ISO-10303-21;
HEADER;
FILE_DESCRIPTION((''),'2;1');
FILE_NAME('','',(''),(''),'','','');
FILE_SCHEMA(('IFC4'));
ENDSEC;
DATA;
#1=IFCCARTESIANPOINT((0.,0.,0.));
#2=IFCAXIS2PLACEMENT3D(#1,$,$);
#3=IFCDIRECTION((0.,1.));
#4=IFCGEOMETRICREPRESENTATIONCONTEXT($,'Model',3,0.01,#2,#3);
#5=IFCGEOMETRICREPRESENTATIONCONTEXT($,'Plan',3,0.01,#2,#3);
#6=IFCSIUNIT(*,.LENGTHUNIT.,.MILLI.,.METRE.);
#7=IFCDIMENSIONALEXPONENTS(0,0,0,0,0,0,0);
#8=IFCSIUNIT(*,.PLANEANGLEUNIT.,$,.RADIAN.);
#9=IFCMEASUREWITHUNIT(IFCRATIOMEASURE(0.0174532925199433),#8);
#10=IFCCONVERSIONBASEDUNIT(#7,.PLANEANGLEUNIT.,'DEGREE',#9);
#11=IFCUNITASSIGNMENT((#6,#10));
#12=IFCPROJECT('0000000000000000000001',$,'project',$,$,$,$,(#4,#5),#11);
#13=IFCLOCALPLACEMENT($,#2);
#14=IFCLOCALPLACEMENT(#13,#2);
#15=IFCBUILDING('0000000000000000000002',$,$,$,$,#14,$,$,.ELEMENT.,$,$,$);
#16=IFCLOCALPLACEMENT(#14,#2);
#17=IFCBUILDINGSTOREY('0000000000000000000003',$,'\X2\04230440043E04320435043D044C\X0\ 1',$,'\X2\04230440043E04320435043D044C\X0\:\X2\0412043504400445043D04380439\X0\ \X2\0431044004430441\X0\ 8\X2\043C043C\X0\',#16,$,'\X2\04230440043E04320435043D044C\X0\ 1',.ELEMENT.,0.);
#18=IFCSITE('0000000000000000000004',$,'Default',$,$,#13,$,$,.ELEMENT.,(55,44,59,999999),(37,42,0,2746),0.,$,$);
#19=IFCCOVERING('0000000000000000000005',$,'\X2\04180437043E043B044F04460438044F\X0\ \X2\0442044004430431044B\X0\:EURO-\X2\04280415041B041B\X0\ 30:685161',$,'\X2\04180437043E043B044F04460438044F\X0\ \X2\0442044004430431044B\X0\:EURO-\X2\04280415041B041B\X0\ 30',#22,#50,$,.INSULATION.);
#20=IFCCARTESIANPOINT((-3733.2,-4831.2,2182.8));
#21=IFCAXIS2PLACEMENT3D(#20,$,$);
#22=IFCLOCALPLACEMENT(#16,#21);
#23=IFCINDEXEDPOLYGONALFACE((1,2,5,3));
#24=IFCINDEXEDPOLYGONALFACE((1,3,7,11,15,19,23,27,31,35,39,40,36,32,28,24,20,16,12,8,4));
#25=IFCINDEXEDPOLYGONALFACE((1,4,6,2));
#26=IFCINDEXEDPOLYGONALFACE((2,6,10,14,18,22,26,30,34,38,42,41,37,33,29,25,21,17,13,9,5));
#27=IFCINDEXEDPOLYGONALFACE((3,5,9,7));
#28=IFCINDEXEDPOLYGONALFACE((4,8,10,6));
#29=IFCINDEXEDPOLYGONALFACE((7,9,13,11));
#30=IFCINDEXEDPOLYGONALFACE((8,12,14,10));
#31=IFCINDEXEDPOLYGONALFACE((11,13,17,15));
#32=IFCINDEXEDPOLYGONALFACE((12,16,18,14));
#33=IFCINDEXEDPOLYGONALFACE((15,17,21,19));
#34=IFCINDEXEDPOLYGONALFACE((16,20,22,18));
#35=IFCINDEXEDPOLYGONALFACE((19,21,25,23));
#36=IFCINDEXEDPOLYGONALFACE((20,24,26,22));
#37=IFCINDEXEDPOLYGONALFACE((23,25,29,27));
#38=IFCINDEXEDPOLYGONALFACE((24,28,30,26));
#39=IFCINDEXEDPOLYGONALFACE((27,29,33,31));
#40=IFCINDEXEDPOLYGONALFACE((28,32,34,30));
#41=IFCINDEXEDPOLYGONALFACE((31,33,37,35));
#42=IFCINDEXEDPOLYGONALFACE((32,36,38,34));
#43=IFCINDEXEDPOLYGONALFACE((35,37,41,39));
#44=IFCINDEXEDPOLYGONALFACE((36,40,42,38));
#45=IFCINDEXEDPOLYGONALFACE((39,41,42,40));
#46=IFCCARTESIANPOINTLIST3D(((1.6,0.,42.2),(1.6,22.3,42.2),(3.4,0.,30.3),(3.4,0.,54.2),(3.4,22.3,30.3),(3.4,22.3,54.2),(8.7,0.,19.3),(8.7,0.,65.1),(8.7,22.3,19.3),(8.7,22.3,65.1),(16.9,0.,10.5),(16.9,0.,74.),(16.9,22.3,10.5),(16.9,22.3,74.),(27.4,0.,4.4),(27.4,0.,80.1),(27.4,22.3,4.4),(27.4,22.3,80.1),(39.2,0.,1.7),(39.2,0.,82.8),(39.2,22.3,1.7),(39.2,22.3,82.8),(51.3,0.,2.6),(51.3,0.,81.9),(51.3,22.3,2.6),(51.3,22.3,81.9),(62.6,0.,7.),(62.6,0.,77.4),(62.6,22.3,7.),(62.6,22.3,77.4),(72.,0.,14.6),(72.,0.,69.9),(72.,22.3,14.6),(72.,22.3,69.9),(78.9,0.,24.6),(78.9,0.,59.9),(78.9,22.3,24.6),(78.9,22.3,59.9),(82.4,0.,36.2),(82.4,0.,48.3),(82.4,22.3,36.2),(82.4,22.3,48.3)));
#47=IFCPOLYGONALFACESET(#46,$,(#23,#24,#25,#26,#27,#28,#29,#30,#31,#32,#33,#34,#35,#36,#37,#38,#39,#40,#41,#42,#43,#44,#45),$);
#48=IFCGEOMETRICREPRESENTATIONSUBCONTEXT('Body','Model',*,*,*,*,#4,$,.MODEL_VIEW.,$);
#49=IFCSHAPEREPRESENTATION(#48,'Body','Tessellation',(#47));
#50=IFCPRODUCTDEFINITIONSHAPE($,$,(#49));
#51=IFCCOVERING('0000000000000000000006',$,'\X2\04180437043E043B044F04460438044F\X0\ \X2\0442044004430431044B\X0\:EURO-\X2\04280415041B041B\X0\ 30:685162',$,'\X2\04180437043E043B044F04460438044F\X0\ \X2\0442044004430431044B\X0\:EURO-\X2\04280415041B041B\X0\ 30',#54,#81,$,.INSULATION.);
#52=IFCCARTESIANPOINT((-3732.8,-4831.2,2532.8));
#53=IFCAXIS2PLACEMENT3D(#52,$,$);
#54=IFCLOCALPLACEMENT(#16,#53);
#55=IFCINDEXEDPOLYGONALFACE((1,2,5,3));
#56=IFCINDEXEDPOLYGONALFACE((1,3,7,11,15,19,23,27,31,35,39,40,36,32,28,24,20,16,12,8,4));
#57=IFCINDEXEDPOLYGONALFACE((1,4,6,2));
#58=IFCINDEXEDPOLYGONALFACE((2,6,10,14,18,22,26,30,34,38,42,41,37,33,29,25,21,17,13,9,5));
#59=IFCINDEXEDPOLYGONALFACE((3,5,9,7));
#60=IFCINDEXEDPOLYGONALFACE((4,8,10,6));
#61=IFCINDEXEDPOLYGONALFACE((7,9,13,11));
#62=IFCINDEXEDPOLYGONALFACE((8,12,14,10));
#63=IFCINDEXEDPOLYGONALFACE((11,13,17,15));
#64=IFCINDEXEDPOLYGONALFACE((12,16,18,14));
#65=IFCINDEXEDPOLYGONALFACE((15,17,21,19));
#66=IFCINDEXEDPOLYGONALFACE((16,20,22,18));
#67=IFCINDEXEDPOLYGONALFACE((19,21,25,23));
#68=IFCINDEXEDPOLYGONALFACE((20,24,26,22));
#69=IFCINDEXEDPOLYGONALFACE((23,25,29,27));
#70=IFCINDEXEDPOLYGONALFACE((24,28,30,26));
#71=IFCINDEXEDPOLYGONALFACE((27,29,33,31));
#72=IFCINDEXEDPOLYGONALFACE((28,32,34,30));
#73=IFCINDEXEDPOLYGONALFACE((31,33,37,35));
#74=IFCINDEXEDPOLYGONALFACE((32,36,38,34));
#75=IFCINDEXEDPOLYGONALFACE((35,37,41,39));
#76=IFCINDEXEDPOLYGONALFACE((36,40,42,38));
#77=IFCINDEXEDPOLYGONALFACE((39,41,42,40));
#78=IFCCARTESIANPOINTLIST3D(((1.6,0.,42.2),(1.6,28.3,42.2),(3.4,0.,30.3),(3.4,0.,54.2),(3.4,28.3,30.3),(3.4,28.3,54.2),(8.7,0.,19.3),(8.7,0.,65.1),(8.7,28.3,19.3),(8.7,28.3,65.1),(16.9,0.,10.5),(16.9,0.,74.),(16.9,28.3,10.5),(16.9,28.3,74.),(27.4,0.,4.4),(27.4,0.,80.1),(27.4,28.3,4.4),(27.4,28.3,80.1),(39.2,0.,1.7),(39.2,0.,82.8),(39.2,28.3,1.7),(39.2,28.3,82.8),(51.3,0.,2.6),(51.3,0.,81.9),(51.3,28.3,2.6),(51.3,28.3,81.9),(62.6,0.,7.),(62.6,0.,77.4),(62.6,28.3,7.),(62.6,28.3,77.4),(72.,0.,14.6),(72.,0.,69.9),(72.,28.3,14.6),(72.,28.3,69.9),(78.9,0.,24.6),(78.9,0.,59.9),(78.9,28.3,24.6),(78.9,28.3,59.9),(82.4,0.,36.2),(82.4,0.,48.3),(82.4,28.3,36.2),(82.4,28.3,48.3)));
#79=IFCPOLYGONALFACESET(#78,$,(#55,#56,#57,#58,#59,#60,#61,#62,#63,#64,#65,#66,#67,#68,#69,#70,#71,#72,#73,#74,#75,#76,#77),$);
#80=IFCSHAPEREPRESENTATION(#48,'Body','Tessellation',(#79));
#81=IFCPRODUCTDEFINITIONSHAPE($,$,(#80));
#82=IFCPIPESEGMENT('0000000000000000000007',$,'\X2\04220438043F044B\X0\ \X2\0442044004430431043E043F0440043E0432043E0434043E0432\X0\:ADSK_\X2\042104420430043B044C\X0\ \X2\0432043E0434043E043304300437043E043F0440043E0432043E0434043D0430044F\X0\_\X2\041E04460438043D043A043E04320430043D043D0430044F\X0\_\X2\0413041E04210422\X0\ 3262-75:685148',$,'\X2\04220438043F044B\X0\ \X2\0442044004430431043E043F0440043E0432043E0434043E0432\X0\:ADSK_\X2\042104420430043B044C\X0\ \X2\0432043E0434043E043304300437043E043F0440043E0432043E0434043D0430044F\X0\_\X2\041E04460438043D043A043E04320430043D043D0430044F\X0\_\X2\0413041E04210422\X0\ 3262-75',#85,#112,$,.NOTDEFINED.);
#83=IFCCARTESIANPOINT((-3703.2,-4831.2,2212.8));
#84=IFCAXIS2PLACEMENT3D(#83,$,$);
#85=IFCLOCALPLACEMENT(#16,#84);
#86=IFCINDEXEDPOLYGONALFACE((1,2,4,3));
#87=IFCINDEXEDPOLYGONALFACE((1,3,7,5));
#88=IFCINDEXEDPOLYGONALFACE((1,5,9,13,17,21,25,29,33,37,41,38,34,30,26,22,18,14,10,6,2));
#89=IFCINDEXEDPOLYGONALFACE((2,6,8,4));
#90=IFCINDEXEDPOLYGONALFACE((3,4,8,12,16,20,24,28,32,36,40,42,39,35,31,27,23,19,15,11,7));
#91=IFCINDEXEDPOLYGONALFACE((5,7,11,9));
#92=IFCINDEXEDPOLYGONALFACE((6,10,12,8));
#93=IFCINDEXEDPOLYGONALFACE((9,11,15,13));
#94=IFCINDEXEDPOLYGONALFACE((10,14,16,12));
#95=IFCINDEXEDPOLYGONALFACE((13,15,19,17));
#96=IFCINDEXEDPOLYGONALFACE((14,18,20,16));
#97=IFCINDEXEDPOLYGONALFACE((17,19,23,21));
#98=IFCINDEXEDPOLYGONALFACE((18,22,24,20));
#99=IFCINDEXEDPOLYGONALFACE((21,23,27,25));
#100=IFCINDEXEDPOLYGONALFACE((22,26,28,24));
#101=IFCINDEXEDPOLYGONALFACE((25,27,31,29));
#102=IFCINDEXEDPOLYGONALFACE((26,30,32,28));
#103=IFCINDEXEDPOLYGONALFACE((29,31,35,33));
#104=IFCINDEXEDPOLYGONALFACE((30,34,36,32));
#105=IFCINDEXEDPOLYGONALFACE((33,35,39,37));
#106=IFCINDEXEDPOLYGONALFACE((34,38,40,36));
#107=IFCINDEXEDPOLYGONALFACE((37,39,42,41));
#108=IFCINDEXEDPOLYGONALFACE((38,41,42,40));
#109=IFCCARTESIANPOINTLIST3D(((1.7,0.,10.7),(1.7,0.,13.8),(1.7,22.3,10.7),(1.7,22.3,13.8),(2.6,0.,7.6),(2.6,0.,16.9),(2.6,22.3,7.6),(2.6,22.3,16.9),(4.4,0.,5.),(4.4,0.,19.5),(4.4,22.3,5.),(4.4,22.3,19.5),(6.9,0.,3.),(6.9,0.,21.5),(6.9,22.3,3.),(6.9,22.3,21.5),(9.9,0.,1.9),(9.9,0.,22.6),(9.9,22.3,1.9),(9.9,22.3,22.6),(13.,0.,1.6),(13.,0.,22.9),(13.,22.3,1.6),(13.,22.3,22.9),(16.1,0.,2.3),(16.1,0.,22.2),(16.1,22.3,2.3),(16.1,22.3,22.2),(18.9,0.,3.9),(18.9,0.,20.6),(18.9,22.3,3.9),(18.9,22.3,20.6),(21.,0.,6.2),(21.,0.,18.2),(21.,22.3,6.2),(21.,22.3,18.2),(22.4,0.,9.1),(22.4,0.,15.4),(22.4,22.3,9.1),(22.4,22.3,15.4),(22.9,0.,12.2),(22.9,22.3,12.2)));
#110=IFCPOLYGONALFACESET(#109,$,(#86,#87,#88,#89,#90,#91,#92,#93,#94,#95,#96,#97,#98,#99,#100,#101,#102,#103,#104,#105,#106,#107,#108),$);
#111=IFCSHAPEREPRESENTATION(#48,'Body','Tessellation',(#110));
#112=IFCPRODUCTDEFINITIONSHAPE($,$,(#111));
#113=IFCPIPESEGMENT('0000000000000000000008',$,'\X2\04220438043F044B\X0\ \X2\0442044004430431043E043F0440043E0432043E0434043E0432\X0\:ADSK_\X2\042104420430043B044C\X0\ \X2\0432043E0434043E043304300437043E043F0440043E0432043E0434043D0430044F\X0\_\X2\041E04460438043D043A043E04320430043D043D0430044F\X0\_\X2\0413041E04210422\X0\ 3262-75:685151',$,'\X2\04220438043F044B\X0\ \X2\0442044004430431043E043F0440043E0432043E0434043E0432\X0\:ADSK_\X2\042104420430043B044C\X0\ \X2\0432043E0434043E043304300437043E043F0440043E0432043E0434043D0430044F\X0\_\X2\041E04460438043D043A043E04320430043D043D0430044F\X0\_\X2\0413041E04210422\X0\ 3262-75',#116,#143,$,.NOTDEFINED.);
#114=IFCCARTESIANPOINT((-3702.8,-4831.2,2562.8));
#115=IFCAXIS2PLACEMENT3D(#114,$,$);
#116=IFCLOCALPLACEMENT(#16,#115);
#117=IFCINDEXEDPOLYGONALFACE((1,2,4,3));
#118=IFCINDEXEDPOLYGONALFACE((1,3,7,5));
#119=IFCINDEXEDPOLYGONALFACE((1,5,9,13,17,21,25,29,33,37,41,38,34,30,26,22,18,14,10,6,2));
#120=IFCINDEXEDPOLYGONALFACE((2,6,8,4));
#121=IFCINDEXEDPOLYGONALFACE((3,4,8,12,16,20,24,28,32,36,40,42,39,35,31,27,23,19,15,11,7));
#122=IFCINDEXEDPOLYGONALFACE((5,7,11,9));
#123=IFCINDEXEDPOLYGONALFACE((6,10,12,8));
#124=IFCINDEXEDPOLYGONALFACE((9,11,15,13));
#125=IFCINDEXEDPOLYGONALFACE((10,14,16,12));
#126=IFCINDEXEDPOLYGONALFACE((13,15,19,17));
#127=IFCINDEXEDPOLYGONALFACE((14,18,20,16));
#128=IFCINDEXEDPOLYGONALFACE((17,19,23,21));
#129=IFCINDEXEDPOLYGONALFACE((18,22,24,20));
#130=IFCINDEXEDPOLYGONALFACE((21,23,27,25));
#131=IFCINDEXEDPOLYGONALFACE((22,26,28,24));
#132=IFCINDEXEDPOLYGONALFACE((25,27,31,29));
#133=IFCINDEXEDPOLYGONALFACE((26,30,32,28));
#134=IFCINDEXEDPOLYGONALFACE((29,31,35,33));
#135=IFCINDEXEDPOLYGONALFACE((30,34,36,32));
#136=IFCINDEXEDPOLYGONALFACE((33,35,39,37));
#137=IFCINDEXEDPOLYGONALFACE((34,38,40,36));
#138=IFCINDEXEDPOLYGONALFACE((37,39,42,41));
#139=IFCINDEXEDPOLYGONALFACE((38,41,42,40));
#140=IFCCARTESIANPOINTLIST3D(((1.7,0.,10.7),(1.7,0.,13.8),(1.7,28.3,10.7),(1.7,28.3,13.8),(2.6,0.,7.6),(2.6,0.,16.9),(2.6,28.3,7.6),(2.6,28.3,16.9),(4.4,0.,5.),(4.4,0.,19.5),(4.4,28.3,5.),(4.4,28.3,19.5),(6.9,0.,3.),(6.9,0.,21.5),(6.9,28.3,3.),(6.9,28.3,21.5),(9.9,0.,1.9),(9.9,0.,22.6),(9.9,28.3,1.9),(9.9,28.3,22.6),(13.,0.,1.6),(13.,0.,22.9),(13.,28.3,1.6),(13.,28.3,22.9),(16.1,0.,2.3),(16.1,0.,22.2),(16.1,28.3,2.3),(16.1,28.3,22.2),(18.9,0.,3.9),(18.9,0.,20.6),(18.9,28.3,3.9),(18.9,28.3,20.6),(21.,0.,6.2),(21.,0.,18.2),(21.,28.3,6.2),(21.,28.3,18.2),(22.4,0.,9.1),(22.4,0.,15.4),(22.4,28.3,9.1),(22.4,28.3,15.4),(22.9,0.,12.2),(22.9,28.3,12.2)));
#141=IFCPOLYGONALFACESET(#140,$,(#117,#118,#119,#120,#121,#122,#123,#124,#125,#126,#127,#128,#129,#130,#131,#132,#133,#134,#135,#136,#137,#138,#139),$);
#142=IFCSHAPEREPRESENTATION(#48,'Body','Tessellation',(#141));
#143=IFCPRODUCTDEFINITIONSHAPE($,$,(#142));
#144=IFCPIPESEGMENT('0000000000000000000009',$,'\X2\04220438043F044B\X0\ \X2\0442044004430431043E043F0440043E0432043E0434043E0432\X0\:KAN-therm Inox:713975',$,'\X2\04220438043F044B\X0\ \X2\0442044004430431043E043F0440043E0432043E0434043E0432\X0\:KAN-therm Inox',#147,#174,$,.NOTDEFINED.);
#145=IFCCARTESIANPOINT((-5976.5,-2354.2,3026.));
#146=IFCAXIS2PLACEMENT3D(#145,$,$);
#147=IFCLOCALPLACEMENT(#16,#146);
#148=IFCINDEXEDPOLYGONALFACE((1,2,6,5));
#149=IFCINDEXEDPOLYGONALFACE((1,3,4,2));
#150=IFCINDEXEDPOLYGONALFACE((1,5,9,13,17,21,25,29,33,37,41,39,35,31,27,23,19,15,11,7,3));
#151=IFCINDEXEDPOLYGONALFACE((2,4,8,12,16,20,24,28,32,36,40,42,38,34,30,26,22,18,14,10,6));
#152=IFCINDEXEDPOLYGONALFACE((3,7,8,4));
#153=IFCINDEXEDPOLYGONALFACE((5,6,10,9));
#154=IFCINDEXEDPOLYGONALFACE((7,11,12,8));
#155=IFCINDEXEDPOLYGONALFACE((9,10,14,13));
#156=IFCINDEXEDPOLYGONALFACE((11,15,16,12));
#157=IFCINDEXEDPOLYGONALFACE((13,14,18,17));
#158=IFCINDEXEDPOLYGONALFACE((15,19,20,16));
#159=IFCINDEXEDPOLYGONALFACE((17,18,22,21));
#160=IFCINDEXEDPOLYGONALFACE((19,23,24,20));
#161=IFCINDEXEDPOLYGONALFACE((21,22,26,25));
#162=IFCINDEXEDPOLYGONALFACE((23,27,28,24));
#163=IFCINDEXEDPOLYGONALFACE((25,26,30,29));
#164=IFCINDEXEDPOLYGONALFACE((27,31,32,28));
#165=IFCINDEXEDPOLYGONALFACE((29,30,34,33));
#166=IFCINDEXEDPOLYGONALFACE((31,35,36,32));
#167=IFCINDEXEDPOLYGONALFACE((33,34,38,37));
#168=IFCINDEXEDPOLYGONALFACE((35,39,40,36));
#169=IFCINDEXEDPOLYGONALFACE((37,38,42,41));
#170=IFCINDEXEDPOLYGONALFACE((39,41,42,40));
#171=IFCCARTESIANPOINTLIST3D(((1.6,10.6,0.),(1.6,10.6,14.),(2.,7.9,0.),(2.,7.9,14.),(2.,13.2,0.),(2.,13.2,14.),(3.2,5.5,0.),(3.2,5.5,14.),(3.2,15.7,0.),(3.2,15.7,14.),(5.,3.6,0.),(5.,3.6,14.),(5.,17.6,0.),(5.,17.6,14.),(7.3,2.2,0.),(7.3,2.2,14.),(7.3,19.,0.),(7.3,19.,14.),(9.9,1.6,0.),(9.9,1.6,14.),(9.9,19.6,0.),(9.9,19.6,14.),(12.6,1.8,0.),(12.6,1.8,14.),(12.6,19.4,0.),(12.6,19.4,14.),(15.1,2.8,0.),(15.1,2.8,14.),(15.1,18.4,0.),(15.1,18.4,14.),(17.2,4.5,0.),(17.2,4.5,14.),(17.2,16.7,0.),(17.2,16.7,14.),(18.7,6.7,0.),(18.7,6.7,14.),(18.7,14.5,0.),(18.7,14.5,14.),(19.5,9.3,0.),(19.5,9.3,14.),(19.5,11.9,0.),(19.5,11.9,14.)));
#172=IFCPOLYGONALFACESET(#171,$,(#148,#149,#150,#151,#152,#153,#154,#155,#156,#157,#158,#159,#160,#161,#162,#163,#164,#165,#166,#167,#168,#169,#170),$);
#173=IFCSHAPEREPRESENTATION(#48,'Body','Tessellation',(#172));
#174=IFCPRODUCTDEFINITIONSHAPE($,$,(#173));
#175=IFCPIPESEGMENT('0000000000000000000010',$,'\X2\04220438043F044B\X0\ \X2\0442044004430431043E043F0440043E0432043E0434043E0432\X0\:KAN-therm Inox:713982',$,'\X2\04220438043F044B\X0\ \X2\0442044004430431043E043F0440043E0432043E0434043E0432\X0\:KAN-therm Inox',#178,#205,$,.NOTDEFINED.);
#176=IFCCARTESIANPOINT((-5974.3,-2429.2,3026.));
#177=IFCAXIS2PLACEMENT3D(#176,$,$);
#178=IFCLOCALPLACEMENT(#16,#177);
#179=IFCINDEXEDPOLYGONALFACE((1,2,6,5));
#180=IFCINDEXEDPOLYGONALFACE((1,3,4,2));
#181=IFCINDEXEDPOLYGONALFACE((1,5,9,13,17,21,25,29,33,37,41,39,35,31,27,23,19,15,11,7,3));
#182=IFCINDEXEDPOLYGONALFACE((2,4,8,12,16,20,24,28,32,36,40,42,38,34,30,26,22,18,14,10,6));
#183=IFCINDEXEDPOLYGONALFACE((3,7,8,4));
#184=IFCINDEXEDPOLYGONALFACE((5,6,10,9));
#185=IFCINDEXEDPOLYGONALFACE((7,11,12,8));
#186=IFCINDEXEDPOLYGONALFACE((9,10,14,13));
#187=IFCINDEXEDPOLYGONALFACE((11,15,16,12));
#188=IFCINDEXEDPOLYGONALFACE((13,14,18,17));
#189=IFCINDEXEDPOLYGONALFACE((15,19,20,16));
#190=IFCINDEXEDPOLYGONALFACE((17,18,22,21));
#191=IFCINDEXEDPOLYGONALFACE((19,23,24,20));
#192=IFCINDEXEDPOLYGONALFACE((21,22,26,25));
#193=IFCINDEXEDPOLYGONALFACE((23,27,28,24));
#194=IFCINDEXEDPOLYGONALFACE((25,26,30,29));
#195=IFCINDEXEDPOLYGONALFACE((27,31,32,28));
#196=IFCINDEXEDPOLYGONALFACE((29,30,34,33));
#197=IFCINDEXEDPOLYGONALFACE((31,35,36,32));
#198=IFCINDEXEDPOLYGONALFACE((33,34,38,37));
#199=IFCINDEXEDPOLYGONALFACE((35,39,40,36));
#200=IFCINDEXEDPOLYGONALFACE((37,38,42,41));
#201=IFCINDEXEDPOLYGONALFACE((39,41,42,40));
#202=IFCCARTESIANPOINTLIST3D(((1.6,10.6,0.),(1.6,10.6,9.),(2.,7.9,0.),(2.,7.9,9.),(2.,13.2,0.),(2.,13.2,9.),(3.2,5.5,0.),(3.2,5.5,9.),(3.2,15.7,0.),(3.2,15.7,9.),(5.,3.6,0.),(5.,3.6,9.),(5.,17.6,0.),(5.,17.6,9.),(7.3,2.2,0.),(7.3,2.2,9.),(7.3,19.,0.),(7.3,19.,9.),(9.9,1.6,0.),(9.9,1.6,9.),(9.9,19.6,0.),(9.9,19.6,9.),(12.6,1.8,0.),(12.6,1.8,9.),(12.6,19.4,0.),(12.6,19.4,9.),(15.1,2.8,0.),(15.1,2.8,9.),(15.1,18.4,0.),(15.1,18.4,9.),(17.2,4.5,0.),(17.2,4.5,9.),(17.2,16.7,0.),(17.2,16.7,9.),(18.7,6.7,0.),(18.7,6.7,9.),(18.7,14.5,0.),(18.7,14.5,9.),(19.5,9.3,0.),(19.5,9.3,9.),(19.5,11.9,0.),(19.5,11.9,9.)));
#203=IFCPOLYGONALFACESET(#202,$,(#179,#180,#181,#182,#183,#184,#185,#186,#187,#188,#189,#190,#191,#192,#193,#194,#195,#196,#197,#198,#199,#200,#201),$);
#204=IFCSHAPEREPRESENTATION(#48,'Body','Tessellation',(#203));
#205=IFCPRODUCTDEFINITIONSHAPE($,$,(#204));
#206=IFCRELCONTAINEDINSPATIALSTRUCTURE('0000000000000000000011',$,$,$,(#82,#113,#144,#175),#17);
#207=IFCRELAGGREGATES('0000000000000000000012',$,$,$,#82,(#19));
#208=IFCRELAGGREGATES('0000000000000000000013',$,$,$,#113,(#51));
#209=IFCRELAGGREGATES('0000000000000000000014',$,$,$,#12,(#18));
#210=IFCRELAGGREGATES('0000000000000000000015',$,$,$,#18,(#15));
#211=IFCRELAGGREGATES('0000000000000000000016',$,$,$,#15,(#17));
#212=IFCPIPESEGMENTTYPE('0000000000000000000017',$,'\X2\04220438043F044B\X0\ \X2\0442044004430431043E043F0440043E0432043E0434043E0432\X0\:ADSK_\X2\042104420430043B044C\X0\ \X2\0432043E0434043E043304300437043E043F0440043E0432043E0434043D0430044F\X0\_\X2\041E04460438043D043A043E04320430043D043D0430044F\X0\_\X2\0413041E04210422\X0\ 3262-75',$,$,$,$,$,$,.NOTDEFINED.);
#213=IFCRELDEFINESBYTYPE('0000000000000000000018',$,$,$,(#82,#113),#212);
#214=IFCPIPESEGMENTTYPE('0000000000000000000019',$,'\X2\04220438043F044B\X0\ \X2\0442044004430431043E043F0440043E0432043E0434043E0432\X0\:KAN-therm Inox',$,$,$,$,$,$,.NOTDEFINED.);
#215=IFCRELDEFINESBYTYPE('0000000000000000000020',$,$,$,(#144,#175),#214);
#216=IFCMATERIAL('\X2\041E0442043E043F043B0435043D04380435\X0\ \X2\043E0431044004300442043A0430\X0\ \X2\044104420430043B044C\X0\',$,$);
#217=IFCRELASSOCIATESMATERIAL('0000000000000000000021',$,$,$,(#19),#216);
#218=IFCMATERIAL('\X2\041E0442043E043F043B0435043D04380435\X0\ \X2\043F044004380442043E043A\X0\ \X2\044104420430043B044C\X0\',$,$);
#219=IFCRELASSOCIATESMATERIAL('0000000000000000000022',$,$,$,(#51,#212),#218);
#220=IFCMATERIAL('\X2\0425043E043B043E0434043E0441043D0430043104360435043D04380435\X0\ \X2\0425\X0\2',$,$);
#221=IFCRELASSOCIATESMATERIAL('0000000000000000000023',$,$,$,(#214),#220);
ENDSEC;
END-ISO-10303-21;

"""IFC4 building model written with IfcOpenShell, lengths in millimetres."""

from ifc_helpers import new_model, entity, si_unit, converted_unit, direction, frame, origin, origin_2d_with_axis, place, context, subcontext, project, spatial, circle, extrude, material, type_object, element, aggregate, save


model = new_model("IFC4")

# Units and contexts
model_context = context("Model", 3, precision=0.01, world=origin(), true_north=direction((0.0, 1.0)))
plan_context = context("Plan", 3, precision=0.01, world=origin(), true_north=direction((0.0, 1.0)))
body_context = subcontext(model_context, "Body", "Model", "MODEL_VIEW")
ifc_project = project(units=[si_unit("LENGTHUNIT", "METRE", prefix="MILLI"), converted_unit("PLANEANGLEUNIT", "DEGREE", entity("IfcRatioMeasure", 0.0174532925199433), si_unit("PLANEANGLEUNIT", "RADIAN"), dimensions=[0, 0, 0, 0, 0, 0, 0])], contexts=[model_context, plan_context])

# Site, building, storey
site_placement = place(None, origin())
site = spatial("IfcSite", under=ifc_project, at=site_placement, Name="Default", CompositionType="ELEMENT", RefLatitude=(55, 44, 59, 999999), RefLongitude=(37, 42, 0, 2746), RefElevation=0.0)
building_placement = place(site_placement, origin())
building = spatial("IfcBuilding", under=site, at=building_placement, CompositionType="ELEMENT")
storey_placement = place(building_placement, origin())
storey = spatial("IfcBuildingStorey", under=building, at=storey_placement, Name="Уровень 1", ObjectType="Уровень:Верхний брус 8мм", LongName="Уровень 1", CompositionType="ELEMENT", Elevation=0.0)

# Coverings
ifc_material_1 = material(Name="Отопление обратка сталь")
covering_1_placement = place(storey_placement, frame((-3733.2, -4831.2, 2182.8)))
covering_1 = element("IfcCovering", 1, at=covering_1_placement, material=ifc_material_1, Name="Изоляция трубы:EURO-ШЕЛЛ 30:685161", ObjectType="Изоляция трубы:EURO-ШЕЛЛ 30", PredefinedType="INSULATION", context=body_context, shape_type="SweptSolid", body=[
    extrude(circle(Radius=40.6, at=origin_2d_with_axis()), frame((42.2, 0.0, 42.2), z_axis=(0.0, 1.0, 0.0), x_axis=(-1.0, 0.0, 0.0)), (0.0, 0.0, 1.0), 22.3),
])
ifc_material_2 = material(Name="Отопление приток сталь")
covering_2_placement = place(storey_placement, frame((-3732.8, -4831.2, 2532.8)))
covering_2 = element("IfcCovering", 2, at=covering_2_placement, material=ifc_material_2, Name="Изоляция трубы:EURO-ШЕЛЛ 30:685162", ObjectType="Изоляция трубы:EURO-ШЕЛЛ 30", PredefinedType="INSULATION", context=body_context, shape_type="SweptSolid", body=[
    extrude(circle(Radius=40.6, at=origin_2d_with_axis()), frame((42.2, 0.0, 42.2), z_axis=(0.0, 1.0, 0.0), x_axis=(-1.0, 0.0, 0.0)), (0.0, 0.0, 1.0), 28.3),
])
ifc_material_3 = material(Name="Холодоснабжение Х2")

# Pipe segments
pipe_segment_type_1 = type_object("IfcPipeSegmentType", Name="Типы трубопроводов:ADSK_Сталь водогазопроводная_Оцинкованная_ГОСТ 3262-75", PredefinedType="NOTDEFINED", material=ifc_material_2)
pipe_segment_1_placement = place(storey_placement, frame((-3703.2, -4831.2, 2212.8)))
pipe_segment_1 = element("IfcPipeSegment", 3, at=pipe_segment_1_placement, inside=storey, type_object=pipe_segment_type_1, Name="Типы трубопроводов:ADSK_Сталь водогазопроводная_Оцинкованная_ГОСТ 3262-75:685148", ObjectType="Типы трубопроводов:ADSK_Сталь водогазопроводная_Оцинкованная_ГОСТ 3262-75", PredefinedType="NOTDEFINED", context=body_context, shape_type="SweptSolid", body=[
    extrude(circle(Radius=10.7, at=origin_2d_with_axis()), frame((12.2, 0.0, 12.2), z_axis=(0.0, 1.0, 0.0), x_axis=(1.0, 0.0, 0.0)), (0.0, 0.0, 1.0), 22.3),
])
aggregate(pipe_segment_1, [covering_1])
pipe_segment_2_placement = place(storey_placement, frame((-3702.8, -4831.2, 2562.8)))
pipe_segment_2 = element("IfcPipeSegment", 4, at=pipe_segment_2_placement, inside=storey, type_object=pipe_segment_type_1, Name="Типы трубопроводов:ADSK_Сталь водогазопроводная_Оцинкованная_ГОСТ 3262-75:685151", ObjectType="Типы трубопроводов:ADSK_Сталь водогазопроводная_Оцинкованная_ГОСТ 3262-75", PredefinedType="NOTDEFINED", context=body_context, shape_type="SweptSolid", body=[
    extrude(circle(Radius=10.7, at=origin_2d_with_axis()), frame((12.2, 0.0, 12.2), z_axis=(0.0, 1.0, 0.0), x_axis=(1.0, 0.0, 0.0)), (0.0, 0.0, 1.0), 28.3),
])
aggregate(pipe_segment_2, [covering_2])
pipe_segment_type_2 = type_object("IfcPipeSegmentType", Name="Типы трубопроводов:KAN-therm Inox", PredefinedType="NOTDEFINED", material=ifc_material_3)
pipe_segment_3_placement = place(storey_placement, frame((-5976.5, -2354.2, 3026.0)))
element("IfcPipeSegment", 5, at=pipe_segment_3_placement, inside=storey, type_object=pipe_segment_type_2, Name="Типы трубопроводов:KAN-therm Inox:713975", ObjectType="Типы трубопроводов:KAN-therm Inox", PredefinedType="NOTDEFINED", context=body_context, shape_type="SweptSolid", body=[
    extrude(circle(Radius=9.0, at=origin_2d_with_axis()), frame((10.6, 10.6, 0.0), z_axis=(0.0, 0.0, 1.0), x_axis=(-1.0, 0.0, 0.0)), (0.0, 0.0, 1.0), 14.0),
])
pipe_segment_4_placement = place(storey_placement, frame((-5974.3, -2429.2, 3026.0)))
element("IfcPipeSegment", 6, at=pipe_segment_4_placement, inside=storey, type_object=pipe_segment_type_2, Name="Типы трубопроводов:KAN-therm Inox:713982", ObjectType="Типы трубопроводов:KAN-therm Inox", PredefinedType="NOTDEFINED", context=body_context, shape_type="SweptSolid", body=[
    extrude(circle(Radius=9.0, at=origin_2d_with_axis()), frame((10.6, 10.6, 0.0), z_axis=(0.0, 0.0, 1.0), x_axis=(-1.0, 0.0, 0.0)), (0.0, 0.0, 1.0), 9.0),
])

save(model, "model.ifc")
